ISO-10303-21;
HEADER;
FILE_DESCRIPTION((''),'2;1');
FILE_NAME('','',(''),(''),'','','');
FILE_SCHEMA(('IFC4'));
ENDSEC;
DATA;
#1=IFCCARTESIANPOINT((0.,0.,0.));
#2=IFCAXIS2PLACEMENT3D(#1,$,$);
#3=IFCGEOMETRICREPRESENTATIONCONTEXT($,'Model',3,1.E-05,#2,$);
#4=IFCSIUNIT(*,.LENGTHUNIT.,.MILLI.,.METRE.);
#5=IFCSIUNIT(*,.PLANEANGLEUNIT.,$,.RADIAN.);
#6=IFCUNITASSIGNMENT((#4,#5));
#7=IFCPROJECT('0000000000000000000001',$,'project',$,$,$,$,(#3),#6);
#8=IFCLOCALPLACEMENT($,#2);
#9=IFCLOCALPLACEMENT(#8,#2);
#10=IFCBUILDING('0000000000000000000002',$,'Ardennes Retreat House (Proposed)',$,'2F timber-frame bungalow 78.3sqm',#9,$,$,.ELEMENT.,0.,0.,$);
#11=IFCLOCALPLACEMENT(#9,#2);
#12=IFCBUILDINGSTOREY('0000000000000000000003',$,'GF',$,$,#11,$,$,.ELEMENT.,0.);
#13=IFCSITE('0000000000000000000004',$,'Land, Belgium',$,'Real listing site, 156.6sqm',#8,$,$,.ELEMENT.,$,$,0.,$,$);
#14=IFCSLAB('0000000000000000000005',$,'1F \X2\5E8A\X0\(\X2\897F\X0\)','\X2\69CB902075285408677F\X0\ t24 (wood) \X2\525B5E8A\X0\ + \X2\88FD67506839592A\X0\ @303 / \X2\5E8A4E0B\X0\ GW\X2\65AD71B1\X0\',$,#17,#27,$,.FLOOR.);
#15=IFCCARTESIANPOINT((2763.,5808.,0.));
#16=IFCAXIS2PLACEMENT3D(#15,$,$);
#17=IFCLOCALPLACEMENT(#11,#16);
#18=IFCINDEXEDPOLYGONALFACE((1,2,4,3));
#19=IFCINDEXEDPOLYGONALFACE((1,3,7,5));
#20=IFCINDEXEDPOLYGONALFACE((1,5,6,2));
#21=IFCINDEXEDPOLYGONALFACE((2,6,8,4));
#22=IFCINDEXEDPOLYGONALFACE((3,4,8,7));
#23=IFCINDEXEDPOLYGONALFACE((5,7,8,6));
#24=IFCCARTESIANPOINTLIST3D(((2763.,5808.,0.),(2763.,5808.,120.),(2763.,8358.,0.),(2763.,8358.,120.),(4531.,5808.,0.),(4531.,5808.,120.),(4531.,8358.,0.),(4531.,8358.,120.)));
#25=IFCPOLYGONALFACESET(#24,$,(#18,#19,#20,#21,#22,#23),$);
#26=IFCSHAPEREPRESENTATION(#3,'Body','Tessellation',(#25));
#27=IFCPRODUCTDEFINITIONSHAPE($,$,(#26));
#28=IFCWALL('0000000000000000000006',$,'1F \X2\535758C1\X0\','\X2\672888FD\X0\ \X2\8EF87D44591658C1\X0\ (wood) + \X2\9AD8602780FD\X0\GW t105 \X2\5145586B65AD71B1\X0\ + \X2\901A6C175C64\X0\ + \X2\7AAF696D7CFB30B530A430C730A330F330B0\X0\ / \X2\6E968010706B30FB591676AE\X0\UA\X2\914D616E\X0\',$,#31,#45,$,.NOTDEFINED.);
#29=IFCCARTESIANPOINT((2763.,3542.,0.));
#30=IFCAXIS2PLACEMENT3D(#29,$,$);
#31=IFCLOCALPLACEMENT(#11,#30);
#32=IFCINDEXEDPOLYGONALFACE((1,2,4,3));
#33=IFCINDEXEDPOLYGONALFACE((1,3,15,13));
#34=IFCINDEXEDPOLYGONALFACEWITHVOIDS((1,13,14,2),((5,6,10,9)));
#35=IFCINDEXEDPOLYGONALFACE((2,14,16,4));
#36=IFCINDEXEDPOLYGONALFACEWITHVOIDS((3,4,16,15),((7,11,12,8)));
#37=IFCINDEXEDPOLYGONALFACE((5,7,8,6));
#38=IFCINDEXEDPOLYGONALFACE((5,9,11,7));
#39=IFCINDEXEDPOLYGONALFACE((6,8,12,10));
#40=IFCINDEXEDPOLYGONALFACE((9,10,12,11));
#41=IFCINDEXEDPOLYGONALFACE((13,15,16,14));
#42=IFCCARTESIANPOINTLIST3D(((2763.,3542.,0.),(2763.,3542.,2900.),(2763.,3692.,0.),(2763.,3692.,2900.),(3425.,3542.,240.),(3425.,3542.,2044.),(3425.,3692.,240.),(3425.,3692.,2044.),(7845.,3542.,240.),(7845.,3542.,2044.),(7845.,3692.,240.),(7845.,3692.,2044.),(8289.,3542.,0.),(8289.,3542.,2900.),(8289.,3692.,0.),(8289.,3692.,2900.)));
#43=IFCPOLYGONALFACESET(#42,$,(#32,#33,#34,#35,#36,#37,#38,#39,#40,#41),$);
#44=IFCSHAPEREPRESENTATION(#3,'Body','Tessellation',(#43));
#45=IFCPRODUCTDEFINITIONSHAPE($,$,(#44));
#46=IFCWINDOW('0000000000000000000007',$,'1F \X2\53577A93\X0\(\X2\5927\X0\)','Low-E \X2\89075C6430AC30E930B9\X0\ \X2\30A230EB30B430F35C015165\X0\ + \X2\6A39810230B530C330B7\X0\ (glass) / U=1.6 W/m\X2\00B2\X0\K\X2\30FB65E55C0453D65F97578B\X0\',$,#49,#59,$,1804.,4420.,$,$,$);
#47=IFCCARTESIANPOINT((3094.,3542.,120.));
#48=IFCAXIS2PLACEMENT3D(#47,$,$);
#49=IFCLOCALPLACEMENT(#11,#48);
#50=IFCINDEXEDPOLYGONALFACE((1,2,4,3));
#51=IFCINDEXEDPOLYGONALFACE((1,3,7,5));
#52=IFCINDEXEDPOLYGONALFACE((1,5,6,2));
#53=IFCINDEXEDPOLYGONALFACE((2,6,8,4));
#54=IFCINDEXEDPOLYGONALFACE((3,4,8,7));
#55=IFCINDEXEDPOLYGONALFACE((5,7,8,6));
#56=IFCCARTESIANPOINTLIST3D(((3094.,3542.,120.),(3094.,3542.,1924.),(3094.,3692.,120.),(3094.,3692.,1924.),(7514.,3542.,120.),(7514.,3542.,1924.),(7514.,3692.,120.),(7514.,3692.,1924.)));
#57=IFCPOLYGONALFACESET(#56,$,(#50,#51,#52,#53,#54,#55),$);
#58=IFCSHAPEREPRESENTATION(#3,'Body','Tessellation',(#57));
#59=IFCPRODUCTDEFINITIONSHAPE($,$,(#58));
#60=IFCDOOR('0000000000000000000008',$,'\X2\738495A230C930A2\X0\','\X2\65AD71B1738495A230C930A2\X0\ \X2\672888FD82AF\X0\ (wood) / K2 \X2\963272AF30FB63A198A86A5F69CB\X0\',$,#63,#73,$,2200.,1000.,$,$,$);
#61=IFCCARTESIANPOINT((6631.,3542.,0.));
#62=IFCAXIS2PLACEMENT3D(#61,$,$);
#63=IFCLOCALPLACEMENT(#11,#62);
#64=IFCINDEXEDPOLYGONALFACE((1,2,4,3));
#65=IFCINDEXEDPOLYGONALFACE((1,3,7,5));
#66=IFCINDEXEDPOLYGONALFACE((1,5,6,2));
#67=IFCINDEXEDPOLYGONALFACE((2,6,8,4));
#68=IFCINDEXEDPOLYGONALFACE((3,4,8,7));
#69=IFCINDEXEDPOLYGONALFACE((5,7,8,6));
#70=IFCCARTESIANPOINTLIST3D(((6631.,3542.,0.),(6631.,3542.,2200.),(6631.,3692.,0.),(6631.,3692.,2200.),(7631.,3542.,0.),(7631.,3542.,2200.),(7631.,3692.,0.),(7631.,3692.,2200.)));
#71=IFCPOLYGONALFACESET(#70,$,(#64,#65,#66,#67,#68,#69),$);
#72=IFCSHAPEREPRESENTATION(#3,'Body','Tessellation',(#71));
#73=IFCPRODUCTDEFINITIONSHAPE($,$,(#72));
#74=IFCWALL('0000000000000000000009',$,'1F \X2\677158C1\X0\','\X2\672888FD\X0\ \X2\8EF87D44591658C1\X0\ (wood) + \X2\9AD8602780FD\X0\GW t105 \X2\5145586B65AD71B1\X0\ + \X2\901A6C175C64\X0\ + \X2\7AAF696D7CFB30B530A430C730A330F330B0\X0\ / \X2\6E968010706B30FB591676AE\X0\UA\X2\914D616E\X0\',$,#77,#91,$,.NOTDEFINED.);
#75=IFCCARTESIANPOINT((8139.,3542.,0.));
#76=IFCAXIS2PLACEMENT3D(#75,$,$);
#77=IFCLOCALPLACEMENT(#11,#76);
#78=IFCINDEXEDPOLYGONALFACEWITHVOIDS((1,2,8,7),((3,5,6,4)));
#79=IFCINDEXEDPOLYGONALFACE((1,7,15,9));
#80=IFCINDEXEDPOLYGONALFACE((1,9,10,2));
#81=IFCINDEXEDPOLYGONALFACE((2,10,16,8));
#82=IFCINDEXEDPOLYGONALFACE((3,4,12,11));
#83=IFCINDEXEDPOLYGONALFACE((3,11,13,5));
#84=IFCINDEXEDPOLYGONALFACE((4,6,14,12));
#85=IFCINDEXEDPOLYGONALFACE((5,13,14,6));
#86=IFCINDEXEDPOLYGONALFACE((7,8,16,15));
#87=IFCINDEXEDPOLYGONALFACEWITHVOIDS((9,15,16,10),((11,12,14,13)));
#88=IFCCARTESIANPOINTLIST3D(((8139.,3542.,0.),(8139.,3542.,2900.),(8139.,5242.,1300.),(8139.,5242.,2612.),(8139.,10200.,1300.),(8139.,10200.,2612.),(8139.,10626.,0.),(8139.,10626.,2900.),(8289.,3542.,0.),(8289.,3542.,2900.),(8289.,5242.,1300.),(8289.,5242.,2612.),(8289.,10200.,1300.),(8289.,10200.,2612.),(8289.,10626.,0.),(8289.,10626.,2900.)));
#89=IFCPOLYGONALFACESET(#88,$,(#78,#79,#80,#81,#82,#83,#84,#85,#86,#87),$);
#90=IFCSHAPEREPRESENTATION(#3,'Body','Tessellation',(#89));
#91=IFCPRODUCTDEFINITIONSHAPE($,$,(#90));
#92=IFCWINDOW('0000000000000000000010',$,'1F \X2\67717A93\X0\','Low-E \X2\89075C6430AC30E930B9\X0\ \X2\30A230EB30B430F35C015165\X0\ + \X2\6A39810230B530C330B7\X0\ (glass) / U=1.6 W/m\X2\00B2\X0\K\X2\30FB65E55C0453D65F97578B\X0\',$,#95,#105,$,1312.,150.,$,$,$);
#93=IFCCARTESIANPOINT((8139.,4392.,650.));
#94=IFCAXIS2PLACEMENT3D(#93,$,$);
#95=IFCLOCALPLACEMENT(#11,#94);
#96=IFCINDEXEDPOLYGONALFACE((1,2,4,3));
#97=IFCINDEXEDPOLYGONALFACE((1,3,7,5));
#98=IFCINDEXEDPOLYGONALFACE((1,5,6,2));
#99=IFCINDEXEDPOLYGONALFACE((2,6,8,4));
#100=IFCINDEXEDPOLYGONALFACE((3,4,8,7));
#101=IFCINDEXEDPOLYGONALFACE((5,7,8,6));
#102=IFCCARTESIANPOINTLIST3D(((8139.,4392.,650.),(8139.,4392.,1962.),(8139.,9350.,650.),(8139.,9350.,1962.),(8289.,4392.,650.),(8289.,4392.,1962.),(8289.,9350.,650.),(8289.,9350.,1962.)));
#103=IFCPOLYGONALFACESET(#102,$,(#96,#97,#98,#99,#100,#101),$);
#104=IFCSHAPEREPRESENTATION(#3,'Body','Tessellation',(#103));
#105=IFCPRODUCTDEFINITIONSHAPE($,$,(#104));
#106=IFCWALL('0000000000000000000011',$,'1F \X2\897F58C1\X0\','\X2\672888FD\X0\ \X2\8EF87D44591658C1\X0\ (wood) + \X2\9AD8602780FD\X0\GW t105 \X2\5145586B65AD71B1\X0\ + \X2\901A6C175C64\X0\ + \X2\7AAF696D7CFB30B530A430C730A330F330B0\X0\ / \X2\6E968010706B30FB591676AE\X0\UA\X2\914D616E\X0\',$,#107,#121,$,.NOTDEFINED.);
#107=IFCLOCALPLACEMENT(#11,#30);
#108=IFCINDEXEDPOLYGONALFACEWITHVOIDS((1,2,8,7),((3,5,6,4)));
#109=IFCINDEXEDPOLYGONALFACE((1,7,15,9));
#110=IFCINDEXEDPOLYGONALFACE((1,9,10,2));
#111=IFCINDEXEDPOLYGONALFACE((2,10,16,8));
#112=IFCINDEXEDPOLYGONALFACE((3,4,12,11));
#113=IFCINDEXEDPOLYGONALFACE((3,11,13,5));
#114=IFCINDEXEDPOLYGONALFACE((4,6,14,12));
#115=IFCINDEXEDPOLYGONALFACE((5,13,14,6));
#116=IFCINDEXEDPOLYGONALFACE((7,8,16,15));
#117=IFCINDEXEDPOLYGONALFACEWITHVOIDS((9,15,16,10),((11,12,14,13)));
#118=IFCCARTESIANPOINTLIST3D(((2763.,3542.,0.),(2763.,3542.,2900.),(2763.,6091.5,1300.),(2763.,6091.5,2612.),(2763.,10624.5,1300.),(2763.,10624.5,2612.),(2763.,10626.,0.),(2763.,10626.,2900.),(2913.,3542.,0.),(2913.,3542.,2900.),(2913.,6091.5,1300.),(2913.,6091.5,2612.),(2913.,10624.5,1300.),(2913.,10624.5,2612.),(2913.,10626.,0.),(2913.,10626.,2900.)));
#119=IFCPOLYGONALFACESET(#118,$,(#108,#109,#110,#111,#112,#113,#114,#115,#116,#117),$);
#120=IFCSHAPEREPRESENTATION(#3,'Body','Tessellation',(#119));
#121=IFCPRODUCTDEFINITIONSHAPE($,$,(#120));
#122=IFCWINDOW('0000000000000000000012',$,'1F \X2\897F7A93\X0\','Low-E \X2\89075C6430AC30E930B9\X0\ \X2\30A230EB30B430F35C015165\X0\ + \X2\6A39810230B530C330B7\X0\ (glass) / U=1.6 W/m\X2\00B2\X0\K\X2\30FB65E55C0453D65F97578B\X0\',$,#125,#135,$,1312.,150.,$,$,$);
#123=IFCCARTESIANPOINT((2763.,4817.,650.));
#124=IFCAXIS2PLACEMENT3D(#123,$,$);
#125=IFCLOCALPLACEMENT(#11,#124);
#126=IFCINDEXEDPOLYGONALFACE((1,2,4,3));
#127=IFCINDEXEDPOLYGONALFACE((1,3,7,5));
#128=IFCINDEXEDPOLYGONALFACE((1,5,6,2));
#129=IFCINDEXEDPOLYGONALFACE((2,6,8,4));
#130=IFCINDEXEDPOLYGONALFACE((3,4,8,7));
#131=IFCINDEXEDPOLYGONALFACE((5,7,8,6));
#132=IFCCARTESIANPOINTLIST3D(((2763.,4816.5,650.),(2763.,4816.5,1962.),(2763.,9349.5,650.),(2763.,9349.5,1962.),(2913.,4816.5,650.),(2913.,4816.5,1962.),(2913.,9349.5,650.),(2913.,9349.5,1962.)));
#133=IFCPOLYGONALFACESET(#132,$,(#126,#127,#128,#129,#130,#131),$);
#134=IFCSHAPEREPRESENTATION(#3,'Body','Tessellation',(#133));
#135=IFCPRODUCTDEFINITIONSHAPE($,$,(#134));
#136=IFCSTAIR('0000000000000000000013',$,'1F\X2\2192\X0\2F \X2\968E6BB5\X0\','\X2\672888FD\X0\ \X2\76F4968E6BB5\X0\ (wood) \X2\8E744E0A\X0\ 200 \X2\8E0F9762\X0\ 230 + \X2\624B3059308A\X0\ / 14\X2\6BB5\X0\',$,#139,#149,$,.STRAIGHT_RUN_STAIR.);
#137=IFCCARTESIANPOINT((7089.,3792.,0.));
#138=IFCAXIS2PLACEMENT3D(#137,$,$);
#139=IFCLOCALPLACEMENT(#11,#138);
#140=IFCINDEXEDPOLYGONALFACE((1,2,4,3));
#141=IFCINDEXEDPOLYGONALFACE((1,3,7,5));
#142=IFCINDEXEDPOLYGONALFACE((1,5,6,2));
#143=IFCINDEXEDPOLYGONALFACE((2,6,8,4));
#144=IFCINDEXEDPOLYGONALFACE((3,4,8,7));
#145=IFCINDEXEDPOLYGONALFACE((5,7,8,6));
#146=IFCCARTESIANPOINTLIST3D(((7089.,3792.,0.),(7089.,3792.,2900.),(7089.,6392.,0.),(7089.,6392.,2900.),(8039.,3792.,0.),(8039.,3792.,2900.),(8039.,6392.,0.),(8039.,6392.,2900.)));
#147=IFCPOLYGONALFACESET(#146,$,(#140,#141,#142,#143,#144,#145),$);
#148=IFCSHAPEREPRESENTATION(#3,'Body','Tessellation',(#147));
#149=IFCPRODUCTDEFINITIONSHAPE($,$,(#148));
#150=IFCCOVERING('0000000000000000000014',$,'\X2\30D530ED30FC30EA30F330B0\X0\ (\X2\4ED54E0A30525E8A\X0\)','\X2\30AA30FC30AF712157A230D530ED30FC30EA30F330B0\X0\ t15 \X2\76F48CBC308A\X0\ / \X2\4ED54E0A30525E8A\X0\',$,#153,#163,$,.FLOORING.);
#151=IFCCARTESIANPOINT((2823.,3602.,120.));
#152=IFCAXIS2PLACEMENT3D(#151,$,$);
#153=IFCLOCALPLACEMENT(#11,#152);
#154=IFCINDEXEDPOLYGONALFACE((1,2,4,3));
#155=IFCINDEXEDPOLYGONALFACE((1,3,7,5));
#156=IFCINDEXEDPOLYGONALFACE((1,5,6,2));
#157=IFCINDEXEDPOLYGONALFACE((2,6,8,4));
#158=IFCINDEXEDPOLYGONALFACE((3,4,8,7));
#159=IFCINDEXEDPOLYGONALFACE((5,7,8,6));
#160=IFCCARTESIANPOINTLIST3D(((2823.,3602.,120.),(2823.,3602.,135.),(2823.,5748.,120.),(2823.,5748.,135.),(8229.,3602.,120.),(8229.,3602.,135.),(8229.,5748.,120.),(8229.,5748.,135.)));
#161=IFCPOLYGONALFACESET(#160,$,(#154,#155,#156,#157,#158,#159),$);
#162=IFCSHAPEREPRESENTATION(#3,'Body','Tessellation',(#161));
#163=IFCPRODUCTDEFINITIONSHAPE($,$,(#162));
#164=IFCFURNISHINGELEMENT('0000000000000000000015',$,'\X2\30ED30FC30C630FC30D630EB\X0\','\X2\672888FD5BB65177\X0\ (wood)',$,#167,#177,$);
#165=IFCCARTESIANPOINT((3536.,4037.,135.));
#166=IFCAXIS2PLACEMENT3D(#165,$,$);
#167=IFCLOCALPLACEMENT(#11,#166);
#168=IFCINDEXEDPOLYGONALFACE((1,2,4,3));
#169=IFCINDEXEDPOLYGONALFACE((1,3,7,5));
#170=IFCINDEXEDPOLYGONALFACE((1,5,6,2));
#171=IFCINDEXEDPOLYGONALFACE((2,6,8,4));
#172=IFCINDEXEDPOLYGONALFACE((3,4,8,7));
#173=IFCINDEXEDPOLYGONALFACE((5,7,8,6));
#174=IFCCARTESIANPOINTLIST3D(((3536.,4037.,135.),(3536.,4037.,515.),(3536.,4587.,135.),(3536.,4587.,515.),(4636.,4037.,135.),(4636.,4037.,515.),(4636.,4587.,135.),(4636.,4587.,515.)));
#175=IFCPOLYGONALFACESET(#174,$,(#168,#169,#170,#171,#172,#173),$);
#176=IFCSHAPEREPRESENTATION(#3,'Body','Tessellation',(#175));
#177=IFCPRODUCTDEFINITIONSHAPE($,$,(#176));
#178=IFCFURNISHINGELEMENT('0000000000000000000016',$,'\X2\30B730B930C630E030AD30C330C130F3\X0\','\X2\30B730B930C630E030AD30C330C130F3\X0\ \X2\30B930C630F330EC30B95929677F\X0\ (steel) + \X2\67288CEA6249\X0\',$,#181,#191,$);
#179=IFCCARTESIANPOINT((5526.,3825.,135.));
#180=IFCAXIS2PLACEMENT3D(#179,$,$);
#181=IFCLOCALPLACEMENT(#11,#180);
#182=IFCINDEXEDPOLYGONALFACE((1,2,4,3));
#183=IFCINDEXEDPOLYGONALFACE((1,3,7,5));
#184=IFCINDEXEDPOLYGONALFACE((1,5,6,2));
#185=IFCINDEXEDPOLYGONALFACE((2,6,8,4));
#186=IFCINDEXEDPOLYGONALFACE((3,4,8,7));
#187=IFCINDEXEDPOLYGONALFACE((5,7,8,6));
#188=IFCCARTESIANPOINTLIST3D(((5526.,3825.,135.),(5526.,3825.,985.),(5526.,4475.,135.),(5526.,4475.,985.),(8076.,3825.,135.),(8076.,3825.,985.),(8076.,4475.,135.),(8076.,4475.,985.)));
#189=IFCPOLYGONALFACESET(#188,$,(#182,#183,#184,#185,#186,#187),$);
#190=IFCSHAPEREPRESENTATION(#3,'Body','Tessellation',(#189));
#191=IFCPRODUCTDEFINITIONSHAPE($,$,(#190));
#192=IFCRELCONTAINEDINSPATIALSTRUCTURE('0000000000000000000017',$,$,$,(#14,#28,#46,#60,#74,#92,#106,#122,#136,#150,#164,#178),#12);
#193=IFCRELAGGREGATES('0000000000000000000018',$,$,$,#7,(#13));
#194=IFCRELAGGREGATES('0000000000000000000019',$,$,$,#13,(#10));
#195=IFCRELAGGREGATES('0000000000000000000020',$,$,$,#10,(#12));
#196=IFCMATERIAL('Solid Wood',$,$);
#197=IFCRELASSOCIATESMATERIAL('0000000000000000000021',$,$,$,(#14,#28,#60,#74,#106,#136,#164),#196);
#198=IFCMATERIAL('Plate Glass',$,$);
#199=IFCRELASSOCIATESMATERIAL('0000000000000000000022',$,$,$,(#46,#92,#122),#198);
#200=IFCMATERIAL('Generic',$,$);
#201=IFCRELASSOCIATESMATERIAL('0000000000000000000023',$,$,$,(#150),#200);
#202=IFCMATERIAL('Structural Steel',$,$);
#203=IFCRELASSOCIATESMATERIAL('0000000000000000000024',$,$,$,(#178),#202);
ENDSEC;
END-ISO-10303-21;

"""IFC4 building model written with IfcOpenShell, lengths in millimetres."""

from ifc_helpers import new_model, si_unit, frame, frame_2d, origin, place, context, project, spatial, rectangle, extrude, material, element, fill, save


model = new_model("IFC4")

# Units and contexts
model_context = context("Model", 3, precision=1e-05, world=origin())
ifc_project = project(units=[si_unit("LENGTHUNIT", "METRE", prefix="MILLI"), si_unit("PLANEANGLEUNIT", "RADIAN")], contexts=[model_context])

# Site, building, storey
site_placement = place(None, origin())
site = spatial("IfcSite", under=ifc_project, at=site_placement, Name="Land, Belgium", ObjectType="Real listing site, 156.6sqm", CompositionType="ELEMENT", RefElevation=0.0)
building_placement = place(site_placement, origin())
building = spatial("IfcBuilding", under=site, at=building_placement, Name="Ardennes Retreat House (Proposed)", ObjectType="2F timber-frame bungalow 78.3sqm", CompositionType="ELEMENT", ElevationOfRefHeight=0.0, ElevationOfTerrain=0.0)
storey_placement = place(building_placement, origin())
storey = spatial("IfcBuildingStorey", under=building, at=storey_placement, Name="GF", CompositionType="ELEMENT", Elevation=0.0)

# Slab
ifc_material_1 = material(Name="Solid Wood")
slab_1_placement = place(storey_placement, frame((2763.0, 5808.0, 0.0)))
element("IfcSlab", 1, at=slab_1_placement, inside=storey, material=ifc_material_1, Name="1F 床(西)", Description="構造用合板 t24 (wood) 剛床 + 製材根太 @303 / 床下 GW断熱", PredefinedType="FLOOR", context=model_context, shape_type="SweptSolid", body=[
    extrude(rectangle(XDim=1768.0, YDim=2550.0, at=frame_2d((884.0, 1275.0))), frame((2763.0, 5808.0, 0.0)), (0.0, 0.0, 1.0), 120.0),
])

# Wall, openings, window, door
wall_1_placement = place(storey_placement, frame((2763.0, 3542.0, 0.0)))
wall_1 = element("IfcWall", 2, at=wall_1_placement, inside=storey, material=ifc_material_1, Name="1F 南壁", Description="木製 軸組外壁 (wood) + 高性能GW t105 充填断熱 + 通気層 + 窯業系サイディング / 準耐火・外皮UA配慮", PredefinedType="NOTDEFINED", context=model_context, shape_type="SweptSolid", body=[
    extrude(rectangle(XDim=5526.0, YDim=150.0, at=frame_2d((2763.0, 75.0))), frame((2763.0, 3542.0, 0.0)), (0.0, 0.0, 1.0), 2900.0),
])
opening_1_placement = place(storey_placement, frame((3094.0, 3542.0, 120.0)))
opening_1 = element("IfcOpeningElement", 3, at=opening_1_placement, cuts=wall_1, PredefinedType="NOTDEFINED", context=model_context, shape_type="SweptSolid", body=[
    extrude(rectangle(XDim=4420.0, YDim=150.0, at=frame_2d((2210.0, 75.0))), frame((3094.0, 3542.0, 120.0)), (0.0, 0.0, 1.0), 1804.0),
])
opening_2_placement = place(storey_placement, frame((6631.0, 3542.0, 0.0)))
opening_2 = element("IfcOpeningElement", 4, at=opening_2_placement, cuts=wall_1, PredefinedType="NOTDEFINED", context=model_context, shape_type="SweptSolid", body=[
    extrude(rectangle(XDim=1000.0, YDim=150.0, at=frame_2d((500.0, 75.0))), frame((6631.0, 3542.0, 0.0)), (0.0, 0.0, 1.0), 2200.0),
])
ifc_material_2 = material(Name="Plate Glass")
window_1_placement = place(storey_placement, frame((3094.0, 3542.0, 120.0)))
window_1 = element("IfcWindow", 5, at=window_1_placement, inside=storey, material=ifc_material_2, Name="1F 南窓(大)", Description="Low-E 複層ガラス アルゴン封入 + 樹脂サッシ (glass) / U=1.6 W/m²K・日射取得型", OverallHeight=1804.0, OverallWidth=4420.0, context=model_context, shape_type="SweptSolid", body=[
    extrude(rectangle(XDim=4420.0, YDim=150.0, at=frame_2d((2210.0, 75.0))), frame((3094.0, 3542.0, 120.0)), (0.0, 0.0, 1.0), 1804.0),
])
fill(opening_1, window_1)
door_placement = place(storey_placement, frame((6631.0, 3542.0, 0.0)))
door = element("IfcDoor", 6, at=door_placement, inside=storey, material=ifc_material_1, Name="玄関ドア", Description="断熱玄関ドア 木製芯 (wood) / K2 防犯・採風機構", OverallHeight=2200.0, OverallWidth=1000.0, context=model_context, shape_type="SweptSolid", body=[
    extrude(rectangle(XDim=1000.0, YDim=150.0, at=frame_2d((500.0, 75.0))), frame((6631.0, 3542.0, 0.0)), (0.0, 0.0, 1.0), 2200.0),
])
fill(opening_2, door)

# Walls, openings, windows
wall_2_placement = place(storey_placement, frame((8139.0, 3542.0, 0.0)))
wall_2 = element("IfcWall", 7, at=wall_2_placement, inside=storey, material=ifc_material_1, Name="1F 東壁", Description="木製 軸組外壁 (wood) + 高性能GW t105 充填断熱 + 通気層 + 窯業系サイディング / 準耐火・外皮UA配慮", PredefinedType="NOTDEFINED", context=model_context, shape_type="SweptSolid", body=[
    extrude(rectangle(XDim=150.0, YDim=7084.0, at=frame_2d((75.0, 3542.0))), frame((8139.0, 3542.0, 0.0)), (0.0, 0.0, 1.0), 2900.0),
])
opening_3_placement = place(storey_placement, frame((8139.0, 4392.0, 650.0)))
opening_3 = element("IfcOpeningElement", 8, at=opening_3_placement, cuts=wall_2, PredefinedType="NOTDEFINED", context=model_context, shape_type="SweptSolid", body=[
    extrude(rectangle(XDim=150.0, YDim=4958.0, at=frame_2d((75.0, 2479.0))), frame((8139.0, 4392.0, 650.0)), (0.0, 0.0, 1.0), 1312.0),
])
window_2_placement = place(storey_placement, frame((8139.0, 4392.0, 650.0)))
window_2 = element("IfcWindow", 9, at=window_2_placement, inside=storey, material=ifc_material_2, Name="1F 東窓", Description="Low-E 複層ガラス アルゴン封入 + 樹脂サッシ (glass) / U=1.6 W/m²K・日射取得型", OverallHeight=1312.0, OverallWidth=150.0, context=model_context, shape_type="SweptSolid", body=[
    extrude(rectangle(XDim=150.0, YDim=4958.0, at=frame_2d((75.0, 2479.0))), frame((8139.0, 4392.0, 650.0)), (0.0, 0.0, 1.0), 1312.0),
])
fill(opening_3, window_2)
wall_3_placement = place(storey_placement, frame((2763.0, 3542.0, 0.0)))
wall_3 = element("IfcWall", 10, at=wall_3_placement, inside=storey, material=ifc_material_1, Name="1F 西壁", Description="木製 軸組外壁 (wood) + 高性能GW t105 充填断熱 + 通気層 + 窯業系サイディング / 準耐火・外皮UA配慮", PredefinedType="NOTDEFINED", context=model_context, shape_type="SweptSolid", body=[
    extrude(rectangle(XDim=150.0, YDim=7084.0, at=frame_2d((75.0, 3542.0))), frame((2763.0, 3542.0, 0.0)), (0.0, 0.0, 1.0), 2900.0),
])
opening_4_placement = place(storey_placement, frame((2763.0, 4817.0, 650.0)))
opening_4 = element("IfcOpeningElement", 11, at=opening_4_placement, cuts=wall_3, PredefinedType="NOTDEFINED", context=model_context, shape_type="SweptSolid", body=[
    extrude(rectangle(XDim=150.0, YDim=4533.0, at=frame_2d((75.0, 2266.0))), frame((2763.0, 4817.0, 650.0)), (0.0, 0.0, 1.0), 1312.0),
])
window_3_placement = place(storey_placement, frame((2763.0, 4817.0, 650.0)))
window_3 = element("IfcWindow", 12, at=window_3_placement, inside=storey, material=ifc_material_2, Name="1F 西窓", Description="Low-E 複層ガラス アルゴン封入 + 樹脂サッシ (glass) / U=1.6 W/m²K・日射取得型", OverallHeight=1312.0, OverallWidth=150.0, context=model_context, shape_type="SweptSolid", body=[
    extrude(rectangle(XDim=150.0, YDim=4533.0, at=frame_2d((75.0, 2266.0))), frame((2763.0, 4817.0, 650.0)), (0.0, 0.0, 1.0), 1312.0),
])
fill(opening_4, window_3)

# Stair
stair_placement = place(storey_placement, frame((7089.0, 3792.0, 0.0)))
element("IfcStair", 13, at=stair_placement, inside=storey, material=ifc_material_1, Name="1F→2F 階段", Description="木製 直階段 (wood) 蹴上 200 踏面 230 + 手すり / 14段", PredefinedType="STRAIGHT_RUN_STAIR", context=model_context, shape_type="SweptSolid", body=[
    extrude(rectangle(XDim=950.0, YDim=2600.0, at=frame_2d((475.0, 1300.0))), frame((7089.0, 3792.0, 0.0)), (0.0, 0.0, 1.0), 2900.0),
])

# Covering
ifc_material_3 = material(Name="Generic")
covering_placement = place(storey_placement, frame((2823.0, 3602.0, 120.0)))
element("IfcCovering", 14, at=covering_placement, inside=storey, material=ifc_material_3, Name="フローリング (仕上げ床)", Description="オーク無垢フローリング t15 直貼り / 仕上げ床", PredefinedType="FLOORING", context=model_context, shape_type="SweptSolid", body=[
    extrude(rectangle(XDim=5406.0, YDim=2146.0, at=frame_2d((2703.0, 1073.0))), frame((2823.0, 3602.0, 120.0)), (0.0, 0.0, 1.0), 15.0),
])

# Furnishing elements
furnishing_1_placement = place(storey_placement, frame((3536.0, 4037.0, 135.0)))
element("IfcFurnishingElement", 15, at=furnishing_1_placement, inside=storey, material=ifc_material_1, Name="ローテーブル", Description="木製家具 (wood)", context=model_context, shape_type="SweptSolid", body=[
    extrude(rectangle(XDim=1100.0, YDim=550.0, at=frame_2d((550.0, 275.0))), frame((3536.0, 4037.0, 135.0)), (0.0, 0.0, 1.0), 380.0),
])
ifc_material_4 = material(Name="Structural Steel")
furnishing_2_placement = place(storey_placement, frame((5526.0, 3825.0, 135.0)))
element("IfcFurnishingElement", 16, at=furnishing_2_placement, inside=storey, material=ifc_material_4, Name="システムキッチン", Description="システムキッチン ステンレス天板 (steel) + 木質扉", context=model_context, shape_type="SweptSolid", body=[
    extrude(rectangle(XDim=2550.0, YDim=650.0, at=frame_2d((1275.0, 325.0))), frame((5526.0, 3825.0, 135.0)), (0.0, 0.0, 1.0), 850.0),
])

save(model, "model.ifc")
